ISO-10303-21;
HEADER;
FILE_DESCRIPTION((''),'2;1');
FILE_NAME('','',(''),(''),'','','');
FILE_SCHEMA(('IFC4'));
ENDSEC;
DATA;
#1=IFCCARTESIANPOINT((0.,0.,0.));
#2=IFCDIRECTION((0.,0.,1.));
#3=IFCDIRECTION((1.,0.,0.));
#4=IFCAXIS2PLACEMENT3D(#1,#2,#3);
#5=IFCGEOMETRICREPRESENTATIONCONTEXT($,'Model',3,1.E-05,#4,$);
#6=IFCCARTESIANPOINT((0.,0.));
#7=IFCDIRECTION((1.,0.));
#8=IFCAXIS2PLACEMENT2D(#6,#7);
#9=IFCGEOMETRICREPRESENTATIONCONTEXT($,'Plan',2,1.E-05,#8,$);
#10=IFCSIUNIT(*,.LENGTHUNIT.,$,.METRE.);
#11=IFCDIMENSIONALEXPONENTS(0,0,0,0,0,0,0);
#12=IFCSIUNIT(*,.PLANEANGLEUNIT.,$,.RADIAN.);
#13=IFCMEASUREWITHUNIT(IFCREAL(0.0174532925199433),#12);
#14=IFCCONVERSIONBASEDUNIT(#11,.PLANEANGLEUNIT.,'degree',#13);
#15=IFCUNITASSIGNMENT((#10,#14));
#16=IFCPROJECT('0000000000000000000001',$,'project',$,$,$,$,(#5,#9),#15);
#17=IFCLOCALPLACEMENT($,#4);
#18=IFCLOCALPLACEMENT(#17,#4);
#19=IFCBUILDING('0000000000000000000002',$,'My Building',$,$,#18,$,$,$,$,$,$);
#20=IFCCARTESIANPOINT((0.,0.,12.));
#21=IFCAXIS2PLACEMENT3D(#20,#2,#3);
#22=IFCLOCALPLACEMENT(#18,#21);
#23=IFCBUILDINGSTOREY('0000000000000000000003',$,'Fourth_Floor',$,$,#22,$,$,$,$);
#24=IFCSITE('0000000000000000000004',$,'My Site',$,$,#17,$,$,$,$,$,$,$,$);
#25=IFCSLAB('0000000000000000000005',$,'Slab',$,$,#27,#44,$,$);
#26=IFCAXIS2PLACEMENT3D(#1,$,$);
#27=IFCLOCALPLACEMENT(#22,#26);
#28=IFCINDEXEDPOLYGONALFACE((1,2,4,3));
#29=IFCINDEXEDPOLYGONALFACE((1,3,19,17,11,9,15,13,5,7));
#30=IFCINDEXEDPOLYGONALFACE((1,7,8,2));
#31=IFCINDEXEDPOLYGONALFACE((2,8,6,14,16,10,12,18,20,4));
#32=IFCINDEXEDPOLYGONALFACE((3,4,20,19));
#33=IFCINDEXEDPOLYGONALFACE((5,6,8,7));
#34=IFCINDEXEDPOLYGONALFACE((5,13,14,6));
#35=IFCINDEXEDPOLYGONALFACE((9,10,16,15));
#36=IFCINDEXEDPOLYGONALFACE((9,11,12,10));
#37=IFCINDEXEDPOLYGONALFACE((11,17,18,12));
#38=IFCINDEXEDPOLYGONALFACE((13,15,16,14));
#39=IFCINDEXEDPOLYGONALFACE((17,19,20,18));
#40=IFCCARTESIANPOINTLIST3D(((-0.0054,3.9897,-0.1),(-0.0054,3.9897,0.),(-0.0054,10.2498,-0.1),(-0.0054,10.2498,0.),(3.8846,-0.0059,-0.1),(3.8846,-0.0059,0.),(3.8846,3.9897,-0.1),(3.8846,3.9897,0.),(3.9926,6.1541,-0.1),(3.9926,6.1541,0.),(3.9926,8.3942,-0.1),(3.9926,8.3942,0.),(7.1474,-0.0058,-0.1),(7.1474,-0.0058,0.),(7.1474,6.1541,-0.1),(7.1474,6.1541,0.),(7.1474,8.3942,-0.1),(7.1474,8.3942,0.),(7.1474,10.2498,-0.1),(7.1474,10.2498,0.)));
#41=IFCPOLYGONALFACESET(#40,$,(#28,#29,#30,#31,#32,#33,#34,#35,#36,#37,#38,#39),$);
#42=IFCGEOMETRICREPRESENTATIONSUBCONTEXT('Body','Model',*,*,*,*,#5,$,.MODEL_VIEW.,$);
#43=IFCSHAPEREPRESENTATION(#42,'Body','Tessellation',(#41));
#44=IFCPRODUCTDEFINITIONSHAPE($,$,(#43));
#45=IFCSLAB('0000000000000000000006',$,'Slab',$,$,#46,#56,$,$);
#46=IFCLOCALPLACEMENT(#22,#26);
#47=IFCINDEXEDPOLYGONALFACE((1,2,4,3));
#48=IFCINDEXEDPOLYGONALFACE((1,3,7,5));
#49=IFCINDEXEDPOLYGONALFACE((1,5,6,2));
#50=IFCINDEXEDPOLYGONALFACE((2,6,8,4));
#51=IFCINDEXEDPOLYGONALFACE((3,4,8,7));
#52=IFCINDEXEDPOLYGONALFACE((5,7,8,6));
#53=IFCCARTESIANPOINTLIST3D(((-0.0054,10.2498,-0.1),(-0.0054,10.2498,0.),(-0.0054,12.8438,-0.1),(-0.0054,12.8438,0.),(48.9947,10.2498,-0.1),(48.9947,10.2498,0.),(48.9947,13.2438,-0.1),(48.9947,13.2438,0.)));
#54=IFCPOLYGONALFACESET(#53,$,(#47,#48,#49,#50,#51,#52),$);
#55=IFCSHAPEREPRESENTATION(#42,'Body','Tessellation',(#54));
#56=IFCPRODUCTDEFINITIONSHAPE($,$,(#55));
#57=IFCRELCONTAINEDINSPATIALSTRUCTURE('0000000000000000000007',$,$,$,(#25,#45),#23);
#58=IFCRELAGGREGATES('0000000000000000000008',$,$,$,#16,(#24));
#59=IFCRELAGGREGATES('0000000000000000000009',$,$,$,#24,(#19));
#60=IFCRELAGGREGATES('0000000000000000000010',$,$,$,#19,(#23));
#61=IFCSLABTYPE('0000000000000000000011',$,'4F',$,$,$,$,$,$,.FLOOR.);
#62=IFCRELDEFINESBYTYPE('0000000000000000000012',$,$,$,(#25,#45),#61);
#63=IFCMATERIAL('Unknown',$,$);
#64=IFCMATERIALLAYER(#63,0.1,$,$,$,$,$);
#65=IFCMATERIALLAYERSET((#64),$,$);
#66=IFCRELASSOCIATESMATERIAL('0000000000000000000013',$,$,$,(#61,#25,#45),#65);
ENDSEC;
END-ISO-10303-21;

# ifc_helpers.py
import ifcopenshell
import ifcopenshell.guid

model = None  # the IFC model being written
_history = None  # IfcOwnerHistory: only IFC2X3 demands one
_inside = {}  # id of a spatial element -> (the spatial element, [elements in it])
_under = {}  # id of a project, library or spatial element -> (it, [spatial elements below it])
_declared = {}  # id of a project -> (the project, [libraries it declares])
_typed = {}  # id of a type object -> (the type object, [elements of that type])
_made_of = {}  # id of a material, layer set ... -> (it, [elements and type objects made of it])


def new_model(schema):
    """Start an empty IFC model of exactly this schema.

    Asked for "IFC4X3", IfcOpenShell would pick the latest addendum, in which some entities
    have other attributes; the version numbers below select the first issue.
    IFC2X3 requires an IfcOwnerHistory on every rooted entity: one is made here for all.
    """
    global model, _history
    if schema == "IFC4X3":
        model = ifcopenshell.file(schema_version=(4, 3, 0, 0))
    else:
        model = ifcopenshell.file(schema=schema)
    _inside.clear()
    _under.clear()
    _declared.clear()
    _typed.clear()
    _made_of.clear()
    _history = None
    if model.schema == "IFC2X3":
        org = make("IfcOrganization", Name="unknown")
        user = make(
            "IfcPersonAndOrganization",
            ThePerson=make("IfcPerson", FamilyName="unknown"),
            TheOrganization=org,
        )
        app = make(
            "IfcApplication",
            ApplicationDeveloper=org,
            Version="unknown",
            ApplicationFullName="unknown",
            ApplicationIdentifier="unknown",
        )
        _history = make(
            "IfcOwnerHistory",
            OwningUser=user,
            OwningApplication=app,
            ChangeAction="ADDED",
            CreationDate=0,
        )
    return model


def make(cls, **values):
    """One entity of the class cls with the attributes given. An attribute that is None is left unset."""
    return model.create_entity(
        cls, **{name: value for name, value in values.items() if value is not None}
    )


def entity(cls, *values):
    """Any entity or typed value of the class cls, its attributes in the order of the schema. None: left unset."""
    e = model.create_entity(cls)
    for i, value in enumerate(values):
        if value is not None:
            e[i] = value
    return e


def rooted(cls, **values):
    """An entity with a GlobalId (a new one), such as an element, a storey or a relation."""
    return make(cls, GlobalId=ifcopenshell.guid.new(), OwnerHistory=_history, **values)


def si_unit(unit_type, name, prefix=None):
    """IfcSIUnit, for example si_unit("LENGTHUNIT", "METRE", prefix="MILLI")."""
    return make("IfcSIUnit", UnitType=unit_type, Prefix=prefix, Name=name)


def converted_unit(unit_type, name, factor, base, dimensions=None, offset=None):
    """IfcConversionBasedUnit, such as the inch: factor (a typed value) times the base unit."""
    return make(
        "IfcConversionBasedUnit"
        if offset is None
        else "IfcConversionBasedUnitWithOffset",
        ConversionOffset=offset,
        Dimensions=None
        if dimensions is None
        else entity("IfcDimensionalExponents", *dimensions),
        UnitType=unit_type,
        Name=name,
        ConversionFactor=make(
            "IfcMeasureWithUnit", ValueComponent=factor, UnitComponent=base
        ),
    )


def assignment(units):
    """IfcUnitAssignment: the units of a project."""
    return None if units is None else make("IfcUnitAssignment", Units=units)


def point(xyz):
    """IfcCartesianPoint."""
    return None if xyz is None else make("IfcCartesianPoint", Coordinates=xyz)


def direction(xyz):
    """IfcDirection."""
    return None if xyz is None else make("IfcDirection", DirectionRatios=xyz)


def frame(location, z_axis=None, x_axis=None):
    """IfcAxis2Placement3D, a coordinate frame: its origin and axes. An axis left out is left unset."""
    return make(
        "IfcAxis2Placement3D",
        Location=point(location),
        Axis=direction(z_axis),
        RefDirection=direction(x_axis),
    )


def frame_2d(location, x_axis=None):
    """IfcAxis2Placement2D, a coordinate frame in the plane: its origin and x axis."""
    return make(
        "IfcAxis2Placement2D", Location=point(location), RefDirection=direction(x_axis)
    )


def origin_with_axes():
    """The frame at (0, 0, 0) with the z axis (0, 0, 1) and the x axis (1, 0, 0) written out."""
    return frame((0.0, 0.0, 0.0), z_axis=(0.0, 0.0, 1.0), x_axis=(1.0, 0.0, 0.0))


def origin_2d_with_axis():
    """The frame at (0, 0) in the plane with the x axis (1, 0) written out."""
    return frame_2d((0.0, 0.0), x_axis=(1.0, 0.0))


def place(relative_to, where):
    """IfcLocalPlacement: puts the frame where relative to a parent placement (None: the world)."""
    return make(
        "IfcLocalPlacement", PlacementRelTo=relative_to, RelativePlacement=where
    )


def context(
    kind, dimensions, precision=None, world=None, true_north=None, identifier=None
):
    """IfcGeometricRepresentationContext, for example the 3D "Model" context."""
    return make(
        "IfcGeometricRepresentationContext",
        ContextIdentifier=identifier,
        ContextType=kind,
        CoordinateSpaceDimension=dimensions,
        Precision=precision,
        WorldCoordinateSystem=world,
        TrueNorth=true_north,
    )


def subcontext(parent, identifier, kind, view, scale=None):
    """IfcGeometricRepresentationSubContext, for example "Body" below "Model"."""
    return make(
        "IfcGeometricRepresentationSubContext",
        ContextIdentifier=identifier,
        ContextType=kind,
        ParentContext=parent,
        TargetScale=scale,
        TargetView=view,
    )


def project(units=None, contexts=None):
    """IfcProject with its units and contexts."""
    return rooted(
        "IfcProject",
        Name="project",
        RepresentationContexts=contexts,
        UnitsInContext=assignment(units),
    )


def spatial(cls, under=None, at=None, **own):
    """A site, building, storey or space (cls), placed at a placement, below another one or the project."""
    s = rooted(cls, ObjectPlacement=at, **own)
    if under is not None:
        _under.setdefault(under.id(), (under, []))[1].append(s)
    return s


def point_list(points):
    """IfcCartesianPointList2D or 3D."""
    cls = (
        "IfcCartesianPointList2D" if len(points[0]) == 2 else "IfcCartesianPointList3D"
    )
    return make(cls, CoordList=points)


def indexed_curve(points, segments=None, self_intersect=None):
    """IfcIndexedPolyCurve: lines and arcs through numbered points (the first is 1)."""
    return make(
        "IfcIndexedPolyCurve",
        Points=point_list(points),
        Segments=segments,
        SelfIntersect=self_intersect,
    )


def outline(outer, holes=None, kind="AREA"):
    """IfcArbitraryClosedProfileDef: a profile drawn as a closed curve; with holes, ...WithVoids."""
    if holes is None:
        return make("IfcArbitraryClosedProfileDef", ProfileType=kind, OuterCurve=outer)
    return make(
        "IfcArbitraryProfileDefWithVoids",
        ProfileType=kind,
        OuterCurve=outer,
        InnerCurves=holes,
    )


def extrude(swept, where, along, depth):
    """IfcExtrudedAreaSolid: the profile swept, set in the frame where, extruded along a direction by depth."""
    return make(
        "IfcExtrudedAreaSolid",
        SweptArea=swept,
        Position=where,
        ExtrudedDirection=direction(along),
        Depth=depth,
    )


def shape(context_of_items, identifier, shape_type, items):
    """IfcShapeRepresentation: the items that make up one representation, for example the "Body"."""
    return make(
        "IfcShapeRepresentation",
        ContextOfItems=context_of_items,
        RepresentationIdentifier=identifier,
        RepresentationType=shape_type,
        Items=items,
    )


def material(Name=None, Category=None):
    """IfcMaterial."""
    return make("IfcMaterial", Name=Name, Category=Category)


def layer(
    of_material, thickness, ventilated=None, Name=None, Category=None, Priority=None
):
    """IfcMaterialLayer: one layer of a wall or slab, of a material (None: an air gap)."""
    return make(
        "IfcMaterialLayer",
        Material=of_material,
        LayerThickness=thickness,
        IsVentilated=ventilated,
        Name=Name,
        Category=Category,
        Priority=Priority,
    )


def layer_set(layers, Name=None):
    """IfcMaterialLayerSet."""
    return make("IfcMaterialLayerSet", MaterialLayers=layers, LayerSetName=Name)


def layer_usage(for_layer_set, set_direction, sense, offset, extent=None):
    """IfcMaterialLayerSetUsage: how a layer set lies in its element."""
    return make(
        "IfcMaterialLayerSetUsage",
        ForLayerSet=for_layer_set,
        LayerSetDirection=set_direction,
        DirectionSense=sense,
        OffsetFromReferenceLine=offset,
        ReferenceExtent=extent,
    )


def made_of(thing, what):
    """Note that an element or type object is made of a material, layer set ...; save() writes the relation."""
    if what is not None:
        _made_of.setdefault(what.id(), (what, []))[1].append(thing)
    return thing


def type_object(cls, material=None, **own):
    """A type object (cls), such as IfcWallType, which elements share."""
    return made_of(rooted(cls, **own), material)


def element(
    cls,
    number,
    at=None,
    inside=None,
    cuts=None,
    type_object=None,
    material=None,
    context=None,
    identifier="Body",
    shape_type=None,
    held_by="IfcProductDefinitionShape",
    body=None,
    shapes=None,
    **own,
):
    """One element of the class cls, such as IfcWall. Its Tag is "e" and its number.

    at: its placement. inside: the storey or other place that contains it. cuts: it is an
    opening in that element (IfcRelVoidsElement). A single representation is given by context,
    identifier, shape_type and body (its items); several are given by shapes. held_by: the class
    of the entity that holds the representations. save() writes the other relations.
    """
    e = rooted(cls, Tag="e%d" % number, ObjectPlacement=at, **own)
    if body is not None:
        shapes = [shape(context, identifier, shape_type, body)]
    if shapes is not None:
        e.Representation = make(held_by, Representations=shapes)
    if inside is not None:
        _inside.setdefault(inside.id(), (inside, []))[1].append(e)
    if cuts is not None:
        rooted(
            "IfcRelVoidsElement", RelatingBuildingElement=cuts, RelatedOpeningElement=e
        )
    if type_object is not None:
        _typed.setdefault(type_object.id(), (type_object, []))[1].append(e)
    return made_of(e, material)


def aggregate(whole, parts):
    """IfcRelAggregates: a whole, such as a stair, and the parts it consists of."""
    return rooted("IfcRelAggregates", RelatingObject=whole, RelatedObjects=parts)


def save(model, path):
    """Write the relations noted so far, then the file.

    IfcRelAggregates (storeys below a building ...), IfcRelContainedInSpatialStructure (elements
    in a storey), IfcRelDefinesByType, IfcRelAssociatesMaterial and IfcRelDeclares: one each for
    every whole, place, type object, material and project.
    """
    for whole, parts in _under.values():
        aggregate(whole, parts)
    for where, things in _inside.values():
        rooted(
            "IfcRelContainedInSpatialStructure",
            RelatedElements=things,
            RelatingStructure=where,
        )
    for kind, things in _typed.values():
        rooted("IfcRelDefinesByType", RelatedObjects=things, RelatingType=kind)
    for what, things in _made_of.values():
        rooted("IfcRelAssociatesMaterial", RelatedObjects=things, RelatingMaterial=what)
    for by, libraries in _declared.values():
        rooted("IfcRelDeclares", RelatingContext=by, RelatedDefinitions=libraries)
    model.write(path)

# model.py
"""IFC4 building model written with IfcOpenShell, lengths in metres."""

from ifc_helpers import new_model, entity, si_unit, converted_unit, frame, origin_with_axes, origin_2d_with_axis, place, context, subcontext, project, spatial, indexed_curve, outline, extrude, material, layer, layer_set, layer_usage, type_object, element, save


model = new_model("IFC4")

# Units and contexts
model_context = context("Model", 3, precision=1e-05, world=origin_with_axes())
plan_context = context("Plan", 2, precision=1e-05, world=origin_2d_with_axis())
body_context = subcontext(model_context, "Body", "Model", "MODEL_VIEW")
ifc_project = project(units=[si_unit("LENGTHUNIT", "METRE"), converted_unit("PLANEANGLEUNIT", "degree", entity("IfcReal", 0.0174532925199433), si_unit("PLANEANGLEUNIT", "RADIAN"), dimensions=[0, 0, 0, 0, 0, 0, 0])], contexts=[model_context, plan_context])

# Site, building, storey
site_placement = place(None, origin_with_axes())
site = spatial("IfcSite", under=ifc_project, at=site_placement, Name="My Site")
building_placement = place(site_placement, origin_with_axes())
building = spatial("IfcBuilding", under=site, at=building_placement, Name="My Building")
storey_placement = place(building_placement, frame((0.0, 0.0, 12.0), z_axis=(0.0, 0.0, 1.0), x_axis=(1.0, 0.0, 0.0)))
storey = spatial("IfcBuildingStorey", under=building, at=storey_placement, Name="Fourth_Floor")

# Shared definitions
ifc_material = material(Name="Unknown")

# Slabs
ifc_layer = layer(ifc_material, 0.1)
ifc_layer_set = layer_set([ifc_layer])
ifc_layer_usage_1 = layer_usage(ifc_layer_set, "AXIS3", "POSITIVE", -0.1)
slab_type = type_object("IfcSlabType", Name="4F", PredefinedType="FLOOR", material=ifc_layer_set)
slab_1_placement = place(storey_placement, frame((7.1474, -0.0058, 0.0), z_axis=(0.0, 0.0, 1.0), x_axis=(1.0, 0.0, 0.0)))
element("IfcSlab", 1, at=slab_1_placement, inside=storey, type_object=slab_type, material=ifc_layer_usage_1, Name="Slab", context=body_context, shape_type="SweptSolid", body=[
    extrude(outline(indexed_curve([(0.0, 0.0), (0.0, 6.16), (-3.1548, 6.16), (-3.1548, 8.4), (0.0, 8.4), (0.0, 10.2556), (-7.1528, 10.2556), (-7.1528, 3.9956), (-3.2628, 3.9956), (-3.2628, -0.0001), (0.0, 0.0)])), frame((0.0, 0.0, -0.1), z_axis=(0.0, 0.0, 1.0), x_axis=(1.0, 0.0, 0.0)), (0.0, 0.0, 1.0), 0.1),
])
ifc_layer_usage_2 = layer_usage(ifc_layer_set, "AXIS3", "POSITIVE", -0.1)
slab_2_placement = place(storey_placement, frame((-0.0054, 12.8438, 0.0), z_axis=(0.0, 0.0, 1.0), x_axis=(1.0, 0.0, 0.0)))
element("IfcSlab", 2, at=slab_2_placement, inside=storey, type_object=slab_type, material=ifc_layer_usage_2, Name="Slab", context=body_context, shape_type="SweptSolid", body=[
    extrude(outline(indexed_curve([(0.0, 0.0), (0.0, -2.594), (49.0001, -2.594), (49.0001, 0.4), (0.0, 0.0)])), frame((0.0, 0.0, -0.1), z_axis=(0.0, 0.0, 1.0), x_axis=(1.0, 0.0, 0.0)), (0.0, 0.0, 1.0), 0.1),
])

save(model, "model.ifc")
